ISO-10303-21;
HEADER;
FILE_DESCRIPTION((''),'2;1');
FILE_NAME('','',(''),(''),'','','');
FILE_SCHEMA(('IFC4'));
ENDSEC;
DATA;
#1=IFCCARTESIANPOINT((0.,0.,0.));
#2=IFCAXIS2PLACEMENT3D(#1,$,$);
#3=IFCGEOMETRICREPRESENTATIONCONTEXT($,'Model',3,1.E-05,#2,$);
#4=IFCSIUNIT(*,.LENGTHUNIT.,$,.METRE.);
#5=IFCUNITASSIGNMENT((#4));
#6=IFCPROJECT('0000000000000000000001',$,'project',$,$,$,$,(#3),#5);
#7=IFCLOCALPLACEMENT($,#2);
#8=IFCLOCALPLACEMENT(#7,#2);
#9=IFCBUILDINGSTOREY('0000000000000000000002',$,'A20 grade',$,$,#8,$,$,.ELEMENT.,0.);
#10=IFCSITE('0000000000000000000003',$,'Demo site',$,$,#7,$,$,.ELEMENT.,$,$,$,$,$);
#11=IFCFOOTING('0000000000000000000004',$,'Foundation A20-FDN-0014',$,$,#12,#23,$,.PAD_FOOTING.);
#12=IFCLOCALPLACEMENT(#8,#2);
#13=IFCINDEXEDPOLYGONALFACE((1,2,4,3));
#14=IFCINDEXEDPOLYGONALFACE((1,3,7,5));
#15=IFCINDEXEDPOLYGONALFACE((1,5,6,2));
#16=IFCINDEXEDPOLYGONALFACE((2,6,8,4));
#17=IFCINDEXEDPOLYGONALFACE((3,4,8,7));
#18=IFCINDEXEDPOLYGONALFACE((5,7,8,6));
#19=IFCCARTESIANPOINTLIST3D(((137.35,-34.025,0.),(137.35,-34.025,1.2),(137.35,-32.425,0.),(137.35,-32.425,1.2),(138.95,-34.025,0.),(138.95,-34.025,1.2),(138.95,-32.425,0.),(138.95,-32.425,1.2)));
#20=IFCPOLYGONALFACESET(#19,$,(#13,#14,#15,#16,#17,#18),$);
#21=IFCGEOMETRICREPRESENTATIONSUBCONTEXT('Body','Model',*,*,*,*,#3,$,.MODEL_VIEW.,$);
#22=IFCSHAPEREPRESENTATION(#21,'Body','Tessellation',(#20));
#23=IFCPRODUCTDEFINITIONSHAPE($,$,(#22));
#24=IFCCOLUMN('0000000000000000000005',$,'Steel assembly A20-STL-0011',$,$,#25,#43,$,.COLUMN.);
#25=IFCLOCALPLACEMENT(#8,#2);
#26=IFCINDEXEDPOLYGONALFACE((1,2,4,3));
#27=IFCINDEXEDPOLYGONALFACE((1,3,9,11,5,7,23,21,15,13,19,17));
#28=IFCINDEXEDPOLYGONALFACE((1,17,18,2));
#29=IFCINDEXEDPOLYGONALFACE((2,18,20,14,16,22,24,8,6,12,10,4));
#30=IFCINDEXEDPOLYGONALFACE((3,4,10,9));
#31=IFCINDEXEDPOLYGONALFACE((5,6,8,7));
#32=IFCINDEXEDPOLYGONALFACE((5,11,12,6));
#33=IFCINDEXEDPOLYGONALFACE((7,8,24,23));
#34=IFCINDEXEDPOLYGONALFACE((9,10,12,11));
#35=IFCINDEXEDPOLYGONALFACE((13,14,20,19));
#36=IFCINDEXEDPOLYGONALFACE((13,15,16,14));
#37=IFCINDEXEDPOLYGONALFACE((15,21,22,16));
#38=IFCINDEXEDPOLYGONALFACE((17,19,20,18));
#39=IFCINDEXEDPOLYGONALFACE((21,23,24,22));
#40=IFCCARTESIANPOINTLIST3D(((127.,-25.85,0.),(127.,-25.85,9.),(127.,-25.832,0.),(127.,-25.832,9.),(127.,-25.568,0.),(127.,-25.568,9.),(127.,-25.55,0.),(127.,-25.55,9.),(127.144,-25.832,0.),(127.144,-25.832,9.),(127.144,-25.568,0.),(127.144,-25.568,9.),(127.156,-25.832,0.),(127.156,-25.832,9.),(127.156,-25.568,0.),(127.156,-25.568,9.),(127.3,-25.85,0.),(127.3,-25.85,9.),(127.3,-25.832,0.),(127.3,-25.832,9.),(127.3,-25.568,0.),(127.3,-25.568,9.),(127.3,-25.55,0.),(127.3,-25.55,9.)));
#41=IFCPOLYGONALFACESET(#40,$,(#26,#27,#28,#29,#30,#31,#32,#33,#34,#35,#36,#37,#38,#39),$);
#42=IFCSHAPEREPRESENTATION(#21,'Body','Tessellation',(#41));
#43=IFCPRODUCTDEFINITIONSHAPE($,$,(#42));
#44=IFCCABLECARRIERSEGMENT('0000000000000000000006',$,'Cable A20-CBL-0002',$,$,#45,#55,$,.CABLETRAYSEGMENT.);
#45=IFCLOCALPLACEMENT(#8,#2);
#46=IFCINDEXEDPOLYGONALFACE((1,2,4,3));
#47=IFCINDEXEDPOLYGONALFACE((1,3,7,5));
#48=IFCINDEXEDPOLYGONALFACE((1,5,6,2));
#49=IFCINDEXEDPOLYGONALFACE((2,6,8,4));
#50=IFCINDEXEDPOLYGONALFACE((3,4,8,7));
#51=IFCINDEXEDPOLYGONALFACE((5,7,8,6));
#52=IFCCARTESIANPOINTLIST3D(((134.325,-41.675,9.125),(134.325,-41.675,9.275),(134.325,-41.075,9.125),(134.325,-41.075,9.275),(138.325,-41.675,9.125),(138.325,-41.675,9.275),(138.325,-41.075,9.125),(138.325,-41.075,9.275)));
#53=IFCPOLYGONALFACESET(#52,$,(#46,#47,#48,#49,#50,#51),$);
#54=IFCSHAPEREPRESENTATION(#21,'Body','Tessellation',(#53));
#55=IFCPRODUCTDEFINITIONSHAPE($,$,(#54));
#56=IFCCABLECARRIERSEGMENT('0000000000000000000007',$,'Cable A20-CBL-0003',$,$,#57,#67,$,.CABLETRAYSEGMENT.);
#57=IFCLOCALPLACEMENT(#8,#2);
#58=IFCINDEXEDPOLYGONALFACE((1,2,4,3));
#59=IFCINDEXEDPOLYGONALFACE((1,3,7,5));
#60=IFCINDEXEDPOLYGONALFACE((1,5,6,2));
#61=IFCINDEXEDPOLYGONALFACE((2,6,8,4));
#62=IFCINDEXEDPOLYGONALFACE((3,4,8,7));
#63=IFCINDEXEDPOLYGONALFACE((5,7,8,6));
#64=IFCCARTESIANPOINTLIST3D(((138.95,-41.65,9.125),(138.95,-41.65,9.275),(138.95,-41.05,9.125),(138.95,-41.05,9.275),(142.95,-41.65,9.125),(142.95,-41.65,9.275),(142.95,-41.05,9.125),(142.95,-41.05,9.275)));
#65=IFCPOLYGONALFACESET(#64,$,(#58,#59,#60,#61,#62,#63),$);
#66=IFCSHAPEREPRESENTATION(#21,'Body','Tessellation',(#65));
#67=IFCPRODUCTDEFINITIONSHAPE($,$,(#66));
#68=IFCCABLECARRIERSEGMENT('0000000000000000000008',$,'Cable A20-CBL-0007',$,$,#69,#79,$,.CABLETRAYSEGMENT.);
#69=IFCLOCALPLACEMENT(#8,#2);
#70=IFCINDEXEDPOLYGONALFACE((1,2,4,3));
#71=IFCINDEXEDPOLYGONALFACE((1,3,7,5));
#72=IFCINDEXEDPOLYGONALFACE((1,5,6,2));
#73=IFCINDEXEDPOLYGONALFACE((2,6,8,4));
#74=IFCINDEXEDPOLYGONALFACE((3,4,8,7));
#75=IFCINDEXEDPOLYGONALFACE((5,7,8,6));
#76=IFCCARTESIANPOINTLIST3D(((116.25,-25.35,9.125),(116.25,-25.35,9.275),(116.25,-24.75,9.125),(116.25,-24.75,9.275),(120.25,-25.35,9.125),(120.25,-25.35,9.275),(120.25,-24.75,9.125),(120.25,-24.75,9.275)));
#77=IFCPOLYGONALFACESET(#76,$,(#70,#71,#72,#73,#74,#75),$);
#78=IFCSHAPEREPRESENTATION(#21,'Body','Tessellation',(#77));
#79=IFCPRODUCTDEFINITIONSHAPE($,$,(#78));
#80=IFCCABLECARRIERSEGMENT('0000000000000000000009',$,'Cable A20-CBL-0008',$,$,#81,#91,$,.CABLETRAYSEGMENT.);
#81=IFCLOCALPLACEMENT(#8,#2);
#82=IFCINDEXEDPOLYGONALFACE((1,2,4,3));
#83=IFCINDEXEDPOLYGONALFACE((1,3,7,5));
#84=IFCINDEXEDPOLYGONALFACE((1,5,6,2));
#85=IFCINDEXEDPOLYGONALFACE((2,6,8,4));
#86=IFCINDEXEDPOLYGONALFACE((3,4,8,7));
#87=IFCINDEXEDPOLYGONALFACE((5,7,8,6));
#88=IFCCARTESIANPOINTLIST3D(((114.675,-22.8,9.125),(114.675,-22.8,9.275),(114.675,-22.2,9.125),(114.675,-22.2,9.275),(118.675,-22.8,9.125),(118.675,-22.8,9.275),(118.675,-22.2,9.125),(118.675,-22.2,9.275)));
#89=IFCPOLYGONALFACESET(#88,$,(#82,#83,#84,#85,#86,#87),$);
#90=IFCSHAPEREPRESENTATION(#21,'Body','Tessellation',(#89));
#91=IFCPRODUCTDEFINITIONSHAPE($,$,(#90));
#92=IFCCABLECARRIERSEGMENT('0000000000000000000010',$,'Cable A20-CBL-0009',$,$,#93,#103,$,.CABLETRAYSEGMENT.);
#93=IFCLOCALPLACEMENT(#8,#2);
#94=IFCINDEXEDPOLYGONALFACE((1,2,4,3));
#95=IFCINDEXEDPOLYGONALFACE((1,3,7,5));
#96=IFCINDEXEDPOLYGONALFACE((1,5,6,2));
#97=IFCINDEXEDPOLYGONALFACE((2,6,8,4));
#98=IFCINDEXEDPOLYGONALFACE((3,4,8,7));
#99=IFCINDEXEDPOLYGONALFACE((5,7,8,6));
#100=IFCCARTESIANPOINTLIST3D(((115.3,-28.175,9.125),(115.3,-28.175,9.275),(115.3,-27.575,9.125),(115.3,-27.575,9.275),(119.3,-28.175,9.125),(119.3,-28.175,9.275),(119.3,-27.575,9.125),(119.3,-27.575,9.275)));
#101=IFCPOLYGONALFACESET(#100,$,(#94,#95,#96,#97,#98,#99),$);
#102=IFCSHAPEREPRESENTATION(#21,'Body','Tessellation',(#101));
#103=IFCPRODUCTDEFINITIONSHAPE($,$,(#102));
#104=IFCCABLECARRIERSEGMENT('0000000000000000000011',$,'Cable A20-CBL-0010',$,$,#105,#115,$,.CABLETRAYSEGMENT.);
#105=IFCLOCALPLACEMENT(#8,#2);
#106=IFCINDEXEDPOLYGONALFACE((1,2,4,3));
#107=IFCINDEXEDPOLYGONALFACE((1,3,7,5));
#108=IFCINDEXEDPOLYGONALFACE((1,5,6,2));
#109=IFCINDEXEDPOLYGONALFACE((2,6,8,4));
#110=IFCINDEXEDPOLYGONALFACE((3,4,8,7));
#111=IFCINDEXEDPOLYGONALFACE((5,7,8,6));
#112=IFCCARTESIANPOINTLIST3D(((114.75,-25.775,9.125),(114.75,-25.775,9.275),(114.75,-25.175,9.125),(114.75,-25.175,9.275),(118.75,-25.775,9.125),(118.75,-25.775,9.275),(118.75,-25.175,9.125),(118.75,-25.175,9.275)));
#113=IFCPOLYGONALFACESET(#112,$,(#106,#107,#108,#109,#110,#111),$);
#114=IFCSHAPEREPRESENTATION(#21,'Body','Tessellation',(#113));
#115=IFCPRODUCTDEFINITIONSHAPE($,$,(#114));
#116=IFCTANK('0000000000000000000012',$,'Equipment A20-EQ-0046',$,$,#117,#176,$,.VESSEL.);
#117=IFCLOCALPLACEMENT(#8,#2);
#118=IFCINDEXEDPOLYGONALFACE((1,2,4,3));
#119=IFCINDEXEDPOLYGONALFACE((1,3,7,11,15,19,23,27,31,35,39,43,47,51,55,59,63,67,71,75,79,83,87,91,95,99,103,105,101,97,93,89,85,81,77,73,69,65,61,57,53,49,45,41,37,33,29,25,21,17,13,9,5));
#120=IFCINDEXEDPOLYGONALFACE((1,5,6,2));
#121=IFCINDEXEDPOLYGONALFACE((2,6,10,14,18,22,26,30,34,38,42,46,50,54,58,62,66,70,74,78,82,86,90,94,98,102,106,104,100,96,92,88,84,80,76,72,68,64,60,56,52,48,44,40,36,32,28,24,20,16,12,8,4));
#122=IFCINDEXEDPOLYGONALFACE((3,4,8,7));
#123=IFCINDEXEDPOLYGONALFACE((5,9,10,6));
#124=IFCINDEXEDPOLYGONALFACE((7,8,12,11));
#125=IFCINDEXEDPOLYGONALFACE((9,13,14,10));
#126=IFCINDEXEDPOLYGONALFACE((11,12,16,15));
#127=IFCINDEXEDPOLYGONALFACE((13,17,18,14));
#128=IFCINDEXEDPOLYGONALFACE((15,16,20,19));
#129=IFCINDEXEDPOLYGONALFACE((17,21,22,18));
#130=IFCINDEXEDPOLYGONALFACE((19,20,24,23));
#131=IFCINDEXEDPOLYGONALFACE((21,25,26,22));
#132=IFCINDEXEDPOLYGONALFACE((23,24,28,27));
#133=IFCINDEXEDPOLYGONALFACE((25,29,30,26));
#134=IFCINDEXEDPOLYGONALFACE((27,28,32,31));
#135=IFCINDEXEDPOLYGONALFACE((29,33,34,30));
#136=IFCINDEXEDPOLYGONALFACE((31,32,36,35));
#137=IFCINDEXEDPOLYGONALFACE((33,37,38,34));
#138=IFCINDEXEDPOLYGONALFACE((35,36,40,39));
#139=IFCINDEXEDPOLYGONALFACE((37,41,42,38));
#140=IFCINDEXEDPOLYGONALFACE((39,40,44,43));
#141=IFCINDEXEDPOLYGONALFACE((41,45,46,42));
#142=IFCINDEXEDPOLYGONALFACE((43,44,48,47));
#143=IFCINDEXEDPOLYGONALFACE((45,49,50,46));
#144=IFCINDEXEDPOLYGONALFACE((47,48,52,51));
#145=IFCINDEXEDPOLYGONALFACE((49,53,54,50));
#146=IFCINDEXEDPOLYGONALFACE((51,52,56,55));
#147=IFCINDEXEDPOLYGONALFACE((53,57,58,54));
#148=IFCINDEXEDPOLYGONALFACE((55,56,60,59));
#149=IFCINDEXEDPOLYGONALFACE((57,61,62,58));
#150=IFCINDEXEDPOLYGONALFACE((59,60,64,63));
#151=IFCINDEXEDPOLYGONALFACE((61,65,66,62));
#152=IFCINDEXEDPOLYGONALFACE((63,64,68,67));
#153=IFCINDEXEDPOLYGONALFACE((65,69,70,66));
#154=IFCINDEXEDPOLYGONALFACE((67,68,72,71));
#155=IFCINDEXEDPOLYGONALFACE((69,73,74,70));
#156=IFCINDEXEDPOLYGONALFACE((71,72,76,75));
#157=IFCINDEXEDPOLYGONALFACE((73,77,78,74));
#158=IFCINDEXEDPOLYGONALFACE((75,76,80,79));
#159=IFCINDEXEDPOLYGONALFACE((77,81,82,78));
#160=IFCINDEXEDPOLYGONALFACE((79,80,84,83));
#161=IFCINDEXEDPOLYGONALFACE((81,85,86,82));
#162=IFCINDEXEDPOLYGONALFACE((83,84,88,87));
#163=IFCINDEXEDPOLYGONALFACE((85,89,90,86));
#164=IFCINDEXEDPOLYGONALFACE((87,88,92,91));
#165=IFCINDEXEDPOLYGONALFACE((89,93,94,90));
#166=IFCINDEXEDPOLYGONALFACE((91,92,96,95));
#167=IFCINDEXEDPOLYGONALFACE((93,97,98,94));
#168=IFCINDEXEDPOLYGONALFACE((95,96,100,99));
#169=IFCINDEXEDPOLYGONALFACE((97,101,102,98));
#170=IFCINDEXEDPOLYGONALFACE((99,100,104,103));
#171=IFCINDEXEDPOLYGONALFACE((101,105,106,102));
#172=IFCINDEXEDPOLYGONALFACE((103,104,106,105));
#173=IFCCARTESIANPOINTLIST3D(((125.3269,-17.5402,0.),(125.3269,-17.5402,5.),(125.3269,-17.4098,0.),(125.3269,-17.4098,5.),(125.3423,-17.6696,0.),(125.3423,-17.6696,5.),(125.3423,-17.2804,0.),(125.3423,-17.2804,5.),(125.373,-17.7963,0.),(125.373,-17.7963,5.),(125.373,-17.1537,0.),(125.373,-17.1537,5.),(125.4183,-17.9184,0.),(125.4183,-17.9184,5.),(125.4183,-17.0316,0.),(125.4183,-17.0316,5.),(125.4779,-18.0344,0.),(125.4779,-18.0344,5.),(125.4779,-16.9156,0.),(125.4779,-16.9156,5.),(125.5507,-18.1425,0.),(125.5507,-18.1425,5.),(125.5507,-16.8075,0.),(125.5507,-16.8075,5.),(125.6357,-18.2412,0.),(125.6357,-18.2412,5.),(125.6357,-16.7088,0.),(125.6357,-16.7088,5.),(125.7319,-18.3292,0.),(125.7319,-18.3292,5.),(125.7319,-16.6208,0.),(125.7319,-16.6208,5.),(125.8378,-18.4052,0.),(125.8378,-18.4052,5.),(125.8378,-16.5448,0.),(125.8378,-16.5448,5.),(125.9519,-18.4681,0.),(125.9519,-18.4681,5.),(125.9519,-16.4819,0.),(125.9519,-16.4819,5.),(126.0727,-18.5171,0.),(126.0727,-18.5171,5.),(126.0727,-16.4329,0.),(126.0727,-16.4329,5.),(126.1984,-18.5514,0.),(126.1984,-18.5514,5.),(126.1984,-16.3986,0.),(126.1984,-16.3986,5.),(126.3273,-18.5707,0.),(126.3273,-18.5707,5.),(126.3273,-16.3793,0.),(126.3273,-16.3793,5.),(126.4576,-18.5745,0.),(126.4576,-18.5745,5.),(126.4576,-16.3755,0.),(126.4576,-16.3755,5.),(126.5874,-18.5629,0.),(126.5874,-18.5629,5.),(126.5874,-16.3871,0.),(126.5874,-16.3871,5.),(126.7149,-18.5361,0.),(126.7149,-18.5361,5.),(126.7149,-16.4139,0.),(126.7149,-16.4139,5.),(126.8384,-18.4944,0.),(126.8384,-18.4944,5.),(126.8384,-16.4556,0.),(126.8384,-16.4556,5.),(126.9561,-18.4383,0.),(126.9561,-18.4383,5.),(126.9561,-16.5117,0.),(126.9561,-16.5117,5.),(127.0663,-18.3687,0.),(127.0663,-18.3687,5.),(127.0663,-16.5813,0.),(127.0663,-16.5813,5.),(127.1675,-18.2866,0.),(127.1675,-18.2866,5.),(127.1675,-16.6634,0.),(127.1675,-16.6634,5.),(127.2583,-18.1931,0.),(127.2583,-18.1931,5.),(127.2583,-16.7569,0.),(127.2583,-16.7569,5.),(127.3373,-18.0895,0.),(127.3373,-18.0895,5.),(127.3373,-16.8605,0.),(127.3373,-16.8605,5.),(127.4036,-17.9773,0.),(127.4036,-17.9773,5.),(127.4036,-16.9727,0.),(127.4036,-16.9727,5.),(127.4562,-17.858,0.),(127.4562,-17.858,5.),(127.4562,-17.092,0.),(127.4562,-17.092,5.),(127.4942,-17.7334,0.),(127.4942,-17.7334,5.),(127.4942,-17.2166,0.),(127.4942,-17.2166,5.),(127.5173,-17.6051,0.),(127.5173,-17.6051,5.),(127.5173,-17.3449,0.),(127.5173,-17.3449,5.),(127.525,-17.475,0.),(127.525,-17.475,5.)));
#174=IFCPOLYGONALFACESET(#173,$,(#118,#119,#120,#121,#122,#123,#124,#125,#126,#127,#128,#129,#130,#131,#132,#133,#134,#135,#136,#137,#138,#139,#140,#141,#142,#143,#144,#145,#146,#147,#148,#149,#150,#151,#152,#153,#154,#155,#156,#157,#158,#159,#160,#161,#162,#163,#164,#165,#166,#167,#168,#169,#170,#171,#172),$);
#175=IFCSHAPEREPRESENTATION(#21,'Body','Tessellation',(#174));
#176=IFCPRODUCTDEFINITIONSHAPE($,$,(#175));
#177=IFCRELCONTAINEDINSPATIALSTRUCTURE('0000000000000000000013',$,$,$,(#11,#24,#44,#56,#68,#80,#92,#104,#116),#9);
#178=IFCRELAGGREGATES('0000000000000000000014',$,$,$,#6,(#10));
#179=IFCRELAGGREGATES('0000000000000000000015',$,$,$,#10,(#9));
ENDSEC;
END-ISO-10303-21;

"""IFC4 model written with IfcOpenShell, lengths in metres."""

from ifc_helpers import new_model, si_unit, frame, origin, place, context, subcontext, project, spatial, rectangle, circle, i_section, extrude, element, save


model = new_model("IFC4")

# Units and contexts
model_context = context("Model", 3, precision=1e-05, world=origin())
body_context = subcontext(model_context, "Body", "Model", "MODEL_VIEW")
ifc_project = project(units=[si_unit("LENGTHUNIT", "METRE")], contexts=[model_context])

# Site, storey
site_placement = place(None, origin())
site = spatial("IfcSite", under=ifc_project, at=site_placement, Name="Demo site", CompositionType="ELEMENT")
storey_placement = place(site_placement, origin())
storey = spatial("IfcBuildingStorey", under=site, at=storey_placement, Name="A20 grade", CompositionType="ELEMENT", Elevation=0.0)

# Footing
footing_placement = place(storey_placement, frame((138.15, -33.225, 0.0)))
element("IfcFooting", 1, at=footing_placement, inside=storey, Name="Foundation A20-FDN-0014", PredefinedType="PAD_FOOTING", context=body_context, shape_type="SweptSolid", body=[
    extrude(rectangle(XDim=1.6, YDim=1.6), origin(), (0.0, 0.0, 1.0), 1.2),
])

# Column
column_placement = place(storey_placement, frame((127.15, -25.7, 0.0)))
element("IfcColumn", 2, at=column_placement, inside=storey, Name="Steel assembly A20-STL-0011", PredefinedType="COLUMN", context=body_context, shape_type="SweptSolid", body=[
    extrude(i_section(OverallWidth=0.3, OverallDepth=0.3, WebThickness=0.012, FlangeThickness=0.018), origin(), (0.0, 0.0, 1.0), 9.0),
])

# Cable carrier segments
for number, where, name in (
    (3, (134.325, -41.375, 9.2), "Cable A20-CBL-0002"),
    (4, (138.95, -41.35, 9.2), "Cable A20-CBL-0003"),
    (5, (116.25, -25.05, 9.2), "Cable A20-CBL-0007"),
    (6, (114.675, -22.5, 9.2), "Cable A20-CBL-0008"),
    (7, (115.3, -27.875, 9.2), "Cable A20-CBL-0009"),
    (8, (114.75, -25.475, 9.2), "Cable A20-CBL-0010"),
):
    element("IfcCableCarrierSegment", number, at=place(storey_placement, frame(where)), inside=storey, Name=name, PredefinedType="CABLETRAYSEGMENT", context=body_context, shape_type="SweptSolid", body=[
        extrude(rectangle(XDim=0.6, YDim=0.15), frame((0.0, 0.0, 0.0), z_axis=(1.0, 0.0, 0.0), x_axis=(0.0, 1.0, 0.0)), (0.0, 0.0, 1.0), 4.0),
    ])

# Tank
for number, where, name in (
    (9, (126.425, -17.475, 0.0), "Equipment A20-EQ-0046"),
):
    element("IfcTank", number, at=place(storey_placement, frame(where)), inside=storey, Name=name, PredefinedType="VESSEL", context=body_context, shape_type="SweptSolid", body=[
        extrude(circle(Radius=1.1), origin(), (0.0, 0.0, 1.0), 5.0),
    ])

save(model, "model.ifc")
